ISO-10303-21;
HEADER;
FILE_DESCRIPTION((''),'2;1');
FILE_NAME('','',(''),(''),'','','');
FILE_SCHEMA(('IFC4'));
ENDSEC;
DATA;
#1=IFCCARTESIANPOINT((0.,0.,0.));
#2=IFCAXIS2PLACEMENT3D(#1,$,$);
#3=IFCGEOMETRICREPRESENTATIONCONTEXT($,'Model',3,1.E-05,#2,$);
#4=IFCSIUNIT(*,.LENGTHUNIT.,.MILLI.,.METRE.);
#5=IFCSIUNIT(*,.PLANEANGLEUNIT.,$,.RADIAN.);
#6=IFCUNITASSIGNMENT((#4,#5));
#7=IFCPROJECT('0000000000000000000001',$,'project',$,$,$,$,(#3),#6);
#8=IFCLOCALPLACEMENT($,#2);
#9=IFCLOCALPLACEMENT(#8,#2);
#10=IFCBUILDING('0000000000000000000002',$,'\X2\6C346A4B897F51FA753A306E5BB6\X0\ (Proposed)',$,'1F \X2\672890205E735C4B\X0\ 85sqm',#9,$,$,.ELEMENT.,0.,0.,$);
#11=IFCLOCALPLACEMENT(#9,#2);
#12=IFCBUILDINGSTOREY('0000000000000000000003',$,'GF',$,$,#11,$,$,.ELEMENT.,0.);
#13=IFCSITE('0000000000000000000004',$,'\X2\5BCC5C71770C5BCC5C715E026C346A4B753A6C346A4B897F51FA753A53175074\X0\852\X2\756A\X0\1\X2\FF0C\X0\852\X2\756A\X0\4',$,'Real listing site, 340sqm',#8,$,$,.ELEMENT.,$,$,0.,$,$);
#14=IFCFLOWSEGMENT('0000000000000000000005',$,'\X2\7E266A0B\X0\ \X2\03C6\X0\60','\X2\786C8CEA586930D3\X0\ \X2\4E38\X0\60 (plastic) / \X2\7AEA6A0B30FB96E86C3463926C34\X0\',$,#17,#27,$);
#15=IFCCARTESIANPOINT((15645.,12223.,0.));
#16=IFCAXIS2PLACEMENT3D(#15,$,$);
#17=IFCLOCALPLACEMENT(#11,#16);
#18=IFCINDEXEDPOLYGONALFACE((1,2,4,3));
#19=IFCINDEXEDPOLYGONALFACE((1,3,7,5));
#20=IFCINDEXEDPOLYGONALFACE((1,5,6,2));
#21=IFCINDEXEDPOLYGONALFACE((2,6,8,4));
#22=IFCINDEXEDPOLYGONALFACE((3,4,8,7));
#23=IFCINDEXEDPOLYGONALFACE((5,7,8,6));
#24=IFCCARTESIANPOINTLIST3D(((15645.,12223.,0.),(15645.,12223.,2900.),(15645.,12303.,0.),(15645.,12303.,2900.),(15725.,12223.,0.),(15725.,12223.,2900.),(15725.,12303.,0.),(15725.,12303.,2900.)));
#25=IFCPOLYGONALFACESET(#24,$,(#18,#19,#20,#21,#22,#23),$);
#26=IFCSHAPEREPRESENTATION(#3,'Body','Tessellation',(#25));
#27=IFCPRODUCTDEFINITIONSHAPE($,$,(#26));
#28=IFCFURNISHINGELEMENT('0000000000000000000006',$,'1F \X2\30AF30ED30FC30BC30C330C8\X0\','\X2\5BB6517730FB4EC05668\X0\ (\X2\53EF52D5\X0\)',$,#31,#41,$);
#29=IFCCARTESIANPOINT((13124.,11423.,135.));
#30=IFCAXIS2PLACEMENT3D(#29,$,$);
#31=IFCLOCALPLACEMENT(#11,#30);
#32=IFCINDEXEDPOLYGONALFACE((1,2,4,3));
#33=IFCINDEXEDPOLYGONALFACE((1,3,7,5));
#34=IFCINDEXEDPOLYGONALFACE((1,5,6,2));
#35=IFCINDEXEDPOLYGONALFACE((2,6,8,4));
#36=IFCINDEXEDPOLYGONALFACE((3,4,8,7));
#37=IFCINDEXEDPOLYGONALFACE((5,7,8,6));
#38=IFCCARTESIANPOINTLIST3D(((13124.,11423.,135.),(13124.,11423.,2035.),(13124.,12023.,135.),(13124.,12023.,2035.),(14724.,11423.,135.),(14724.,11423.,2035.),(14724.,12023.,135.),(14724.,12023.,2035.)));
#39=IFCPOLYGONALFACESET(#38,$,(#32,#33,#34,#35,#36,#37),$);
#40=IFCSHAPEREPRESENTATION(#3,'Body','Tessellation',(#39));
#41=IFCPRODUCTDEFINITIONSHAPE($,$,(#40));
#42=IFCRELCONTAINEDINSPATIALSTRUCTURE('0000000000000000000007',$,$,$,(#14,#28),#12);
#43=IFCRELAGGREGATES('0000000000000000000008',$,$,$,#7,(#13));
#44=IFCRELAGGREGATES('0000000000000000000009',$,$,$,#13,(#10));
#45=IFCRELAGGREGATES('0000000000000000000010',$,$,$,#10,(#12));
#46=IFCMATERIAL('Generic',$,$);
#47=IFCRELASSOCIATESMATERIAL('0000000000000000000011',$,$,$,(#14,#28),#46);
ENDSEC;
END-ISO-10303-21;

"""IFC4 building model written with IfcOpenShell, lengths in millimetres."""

from ifc_helpers import new_model, si_unit, frame, frame_2d, origin, place, context, project, spatial, rectangle, extrude, material, element, save


model = new_model("IFC4")

# Units and contexts
model_context = context("Model", 3, precision=1e-05, world=origin())
ifc_project = project(units=[si_unit("LENGTHUNIT", "METRE", prefix="MILLI"), si_unit("PLANEANGLEUNIT", "RADIAN")], contexts=[model_context])

# Site, building, storey
site_placement = place(None, origin())
site = spatial("IfcSite", under=ifc_project, at=site_placement, Name="富山県富山市水橋町水橋西出町北側852番1，852番4", ObjectType="Real listing site, 340sqm", CompositionType="ELEMENT", RefElevation=0.0)
building_placement = place(site_placement, origin())
building = spatial("IfcBuilding", under=site, at=building_placement, Name="水橋西出町の家 (Proposed)", ObjectType="1F 木造平屋 85sqm", CompositionType="ELEMENT", ElevationOfRefHeight=0.0, ElevationOfTerrain=0.0)
storey_placement = place(building_placement, origin())
storey = spatial("IfcBuildingStorey", under=building, at=storey_placement, Name="GF", CompositionType="ELEMENT", Elevation=0.0)

# Shared definitions
ifc_material_1 = material(Name="Generic")

# Flow segment
flow_segment_placement = place(storey_placement, frame((15645.0, 12223.0, 0.0)))
element("IfcFlowSegment", 1, at=flow_segment_placement, inside=storey, material=ifc_material_1, Name="縦樋 φ60", Description="硬質塩ビ 丸60 (plastic) / 竪樋・雨水排水", context=model_context, shape_type="SweptSolid", body=[
    extrude(rectangle(XDim=80.0, YDim=80.0, at=frame_2d((40.0, 40.0))), frame((15645.0, 12223.0, 0.0)), (0.0, 0.0, 1.0), 2900.0),
])

# Furnishing element
furnishing_placement = place(storey_placement, frame((13124.0, 11423.0, 135.0)))
element("IfcFurnishingElement", 2, at=furnishing_placement, inside=storey, material=ifc_material_1, Name="1F クローゼット", Description="家具・什器 (可動)", context=model_context, shape_type="SweptSolid", body=[
    extrude(rectangle(XDim=1600.0, YDim=600.0, at=frame_2d((800.0, 300.0))), frame((13124.0, 11423.0, 135.0)), (0.0, 0.0, 1.0), 1900.0),
])

save(model, "model.ifc")
